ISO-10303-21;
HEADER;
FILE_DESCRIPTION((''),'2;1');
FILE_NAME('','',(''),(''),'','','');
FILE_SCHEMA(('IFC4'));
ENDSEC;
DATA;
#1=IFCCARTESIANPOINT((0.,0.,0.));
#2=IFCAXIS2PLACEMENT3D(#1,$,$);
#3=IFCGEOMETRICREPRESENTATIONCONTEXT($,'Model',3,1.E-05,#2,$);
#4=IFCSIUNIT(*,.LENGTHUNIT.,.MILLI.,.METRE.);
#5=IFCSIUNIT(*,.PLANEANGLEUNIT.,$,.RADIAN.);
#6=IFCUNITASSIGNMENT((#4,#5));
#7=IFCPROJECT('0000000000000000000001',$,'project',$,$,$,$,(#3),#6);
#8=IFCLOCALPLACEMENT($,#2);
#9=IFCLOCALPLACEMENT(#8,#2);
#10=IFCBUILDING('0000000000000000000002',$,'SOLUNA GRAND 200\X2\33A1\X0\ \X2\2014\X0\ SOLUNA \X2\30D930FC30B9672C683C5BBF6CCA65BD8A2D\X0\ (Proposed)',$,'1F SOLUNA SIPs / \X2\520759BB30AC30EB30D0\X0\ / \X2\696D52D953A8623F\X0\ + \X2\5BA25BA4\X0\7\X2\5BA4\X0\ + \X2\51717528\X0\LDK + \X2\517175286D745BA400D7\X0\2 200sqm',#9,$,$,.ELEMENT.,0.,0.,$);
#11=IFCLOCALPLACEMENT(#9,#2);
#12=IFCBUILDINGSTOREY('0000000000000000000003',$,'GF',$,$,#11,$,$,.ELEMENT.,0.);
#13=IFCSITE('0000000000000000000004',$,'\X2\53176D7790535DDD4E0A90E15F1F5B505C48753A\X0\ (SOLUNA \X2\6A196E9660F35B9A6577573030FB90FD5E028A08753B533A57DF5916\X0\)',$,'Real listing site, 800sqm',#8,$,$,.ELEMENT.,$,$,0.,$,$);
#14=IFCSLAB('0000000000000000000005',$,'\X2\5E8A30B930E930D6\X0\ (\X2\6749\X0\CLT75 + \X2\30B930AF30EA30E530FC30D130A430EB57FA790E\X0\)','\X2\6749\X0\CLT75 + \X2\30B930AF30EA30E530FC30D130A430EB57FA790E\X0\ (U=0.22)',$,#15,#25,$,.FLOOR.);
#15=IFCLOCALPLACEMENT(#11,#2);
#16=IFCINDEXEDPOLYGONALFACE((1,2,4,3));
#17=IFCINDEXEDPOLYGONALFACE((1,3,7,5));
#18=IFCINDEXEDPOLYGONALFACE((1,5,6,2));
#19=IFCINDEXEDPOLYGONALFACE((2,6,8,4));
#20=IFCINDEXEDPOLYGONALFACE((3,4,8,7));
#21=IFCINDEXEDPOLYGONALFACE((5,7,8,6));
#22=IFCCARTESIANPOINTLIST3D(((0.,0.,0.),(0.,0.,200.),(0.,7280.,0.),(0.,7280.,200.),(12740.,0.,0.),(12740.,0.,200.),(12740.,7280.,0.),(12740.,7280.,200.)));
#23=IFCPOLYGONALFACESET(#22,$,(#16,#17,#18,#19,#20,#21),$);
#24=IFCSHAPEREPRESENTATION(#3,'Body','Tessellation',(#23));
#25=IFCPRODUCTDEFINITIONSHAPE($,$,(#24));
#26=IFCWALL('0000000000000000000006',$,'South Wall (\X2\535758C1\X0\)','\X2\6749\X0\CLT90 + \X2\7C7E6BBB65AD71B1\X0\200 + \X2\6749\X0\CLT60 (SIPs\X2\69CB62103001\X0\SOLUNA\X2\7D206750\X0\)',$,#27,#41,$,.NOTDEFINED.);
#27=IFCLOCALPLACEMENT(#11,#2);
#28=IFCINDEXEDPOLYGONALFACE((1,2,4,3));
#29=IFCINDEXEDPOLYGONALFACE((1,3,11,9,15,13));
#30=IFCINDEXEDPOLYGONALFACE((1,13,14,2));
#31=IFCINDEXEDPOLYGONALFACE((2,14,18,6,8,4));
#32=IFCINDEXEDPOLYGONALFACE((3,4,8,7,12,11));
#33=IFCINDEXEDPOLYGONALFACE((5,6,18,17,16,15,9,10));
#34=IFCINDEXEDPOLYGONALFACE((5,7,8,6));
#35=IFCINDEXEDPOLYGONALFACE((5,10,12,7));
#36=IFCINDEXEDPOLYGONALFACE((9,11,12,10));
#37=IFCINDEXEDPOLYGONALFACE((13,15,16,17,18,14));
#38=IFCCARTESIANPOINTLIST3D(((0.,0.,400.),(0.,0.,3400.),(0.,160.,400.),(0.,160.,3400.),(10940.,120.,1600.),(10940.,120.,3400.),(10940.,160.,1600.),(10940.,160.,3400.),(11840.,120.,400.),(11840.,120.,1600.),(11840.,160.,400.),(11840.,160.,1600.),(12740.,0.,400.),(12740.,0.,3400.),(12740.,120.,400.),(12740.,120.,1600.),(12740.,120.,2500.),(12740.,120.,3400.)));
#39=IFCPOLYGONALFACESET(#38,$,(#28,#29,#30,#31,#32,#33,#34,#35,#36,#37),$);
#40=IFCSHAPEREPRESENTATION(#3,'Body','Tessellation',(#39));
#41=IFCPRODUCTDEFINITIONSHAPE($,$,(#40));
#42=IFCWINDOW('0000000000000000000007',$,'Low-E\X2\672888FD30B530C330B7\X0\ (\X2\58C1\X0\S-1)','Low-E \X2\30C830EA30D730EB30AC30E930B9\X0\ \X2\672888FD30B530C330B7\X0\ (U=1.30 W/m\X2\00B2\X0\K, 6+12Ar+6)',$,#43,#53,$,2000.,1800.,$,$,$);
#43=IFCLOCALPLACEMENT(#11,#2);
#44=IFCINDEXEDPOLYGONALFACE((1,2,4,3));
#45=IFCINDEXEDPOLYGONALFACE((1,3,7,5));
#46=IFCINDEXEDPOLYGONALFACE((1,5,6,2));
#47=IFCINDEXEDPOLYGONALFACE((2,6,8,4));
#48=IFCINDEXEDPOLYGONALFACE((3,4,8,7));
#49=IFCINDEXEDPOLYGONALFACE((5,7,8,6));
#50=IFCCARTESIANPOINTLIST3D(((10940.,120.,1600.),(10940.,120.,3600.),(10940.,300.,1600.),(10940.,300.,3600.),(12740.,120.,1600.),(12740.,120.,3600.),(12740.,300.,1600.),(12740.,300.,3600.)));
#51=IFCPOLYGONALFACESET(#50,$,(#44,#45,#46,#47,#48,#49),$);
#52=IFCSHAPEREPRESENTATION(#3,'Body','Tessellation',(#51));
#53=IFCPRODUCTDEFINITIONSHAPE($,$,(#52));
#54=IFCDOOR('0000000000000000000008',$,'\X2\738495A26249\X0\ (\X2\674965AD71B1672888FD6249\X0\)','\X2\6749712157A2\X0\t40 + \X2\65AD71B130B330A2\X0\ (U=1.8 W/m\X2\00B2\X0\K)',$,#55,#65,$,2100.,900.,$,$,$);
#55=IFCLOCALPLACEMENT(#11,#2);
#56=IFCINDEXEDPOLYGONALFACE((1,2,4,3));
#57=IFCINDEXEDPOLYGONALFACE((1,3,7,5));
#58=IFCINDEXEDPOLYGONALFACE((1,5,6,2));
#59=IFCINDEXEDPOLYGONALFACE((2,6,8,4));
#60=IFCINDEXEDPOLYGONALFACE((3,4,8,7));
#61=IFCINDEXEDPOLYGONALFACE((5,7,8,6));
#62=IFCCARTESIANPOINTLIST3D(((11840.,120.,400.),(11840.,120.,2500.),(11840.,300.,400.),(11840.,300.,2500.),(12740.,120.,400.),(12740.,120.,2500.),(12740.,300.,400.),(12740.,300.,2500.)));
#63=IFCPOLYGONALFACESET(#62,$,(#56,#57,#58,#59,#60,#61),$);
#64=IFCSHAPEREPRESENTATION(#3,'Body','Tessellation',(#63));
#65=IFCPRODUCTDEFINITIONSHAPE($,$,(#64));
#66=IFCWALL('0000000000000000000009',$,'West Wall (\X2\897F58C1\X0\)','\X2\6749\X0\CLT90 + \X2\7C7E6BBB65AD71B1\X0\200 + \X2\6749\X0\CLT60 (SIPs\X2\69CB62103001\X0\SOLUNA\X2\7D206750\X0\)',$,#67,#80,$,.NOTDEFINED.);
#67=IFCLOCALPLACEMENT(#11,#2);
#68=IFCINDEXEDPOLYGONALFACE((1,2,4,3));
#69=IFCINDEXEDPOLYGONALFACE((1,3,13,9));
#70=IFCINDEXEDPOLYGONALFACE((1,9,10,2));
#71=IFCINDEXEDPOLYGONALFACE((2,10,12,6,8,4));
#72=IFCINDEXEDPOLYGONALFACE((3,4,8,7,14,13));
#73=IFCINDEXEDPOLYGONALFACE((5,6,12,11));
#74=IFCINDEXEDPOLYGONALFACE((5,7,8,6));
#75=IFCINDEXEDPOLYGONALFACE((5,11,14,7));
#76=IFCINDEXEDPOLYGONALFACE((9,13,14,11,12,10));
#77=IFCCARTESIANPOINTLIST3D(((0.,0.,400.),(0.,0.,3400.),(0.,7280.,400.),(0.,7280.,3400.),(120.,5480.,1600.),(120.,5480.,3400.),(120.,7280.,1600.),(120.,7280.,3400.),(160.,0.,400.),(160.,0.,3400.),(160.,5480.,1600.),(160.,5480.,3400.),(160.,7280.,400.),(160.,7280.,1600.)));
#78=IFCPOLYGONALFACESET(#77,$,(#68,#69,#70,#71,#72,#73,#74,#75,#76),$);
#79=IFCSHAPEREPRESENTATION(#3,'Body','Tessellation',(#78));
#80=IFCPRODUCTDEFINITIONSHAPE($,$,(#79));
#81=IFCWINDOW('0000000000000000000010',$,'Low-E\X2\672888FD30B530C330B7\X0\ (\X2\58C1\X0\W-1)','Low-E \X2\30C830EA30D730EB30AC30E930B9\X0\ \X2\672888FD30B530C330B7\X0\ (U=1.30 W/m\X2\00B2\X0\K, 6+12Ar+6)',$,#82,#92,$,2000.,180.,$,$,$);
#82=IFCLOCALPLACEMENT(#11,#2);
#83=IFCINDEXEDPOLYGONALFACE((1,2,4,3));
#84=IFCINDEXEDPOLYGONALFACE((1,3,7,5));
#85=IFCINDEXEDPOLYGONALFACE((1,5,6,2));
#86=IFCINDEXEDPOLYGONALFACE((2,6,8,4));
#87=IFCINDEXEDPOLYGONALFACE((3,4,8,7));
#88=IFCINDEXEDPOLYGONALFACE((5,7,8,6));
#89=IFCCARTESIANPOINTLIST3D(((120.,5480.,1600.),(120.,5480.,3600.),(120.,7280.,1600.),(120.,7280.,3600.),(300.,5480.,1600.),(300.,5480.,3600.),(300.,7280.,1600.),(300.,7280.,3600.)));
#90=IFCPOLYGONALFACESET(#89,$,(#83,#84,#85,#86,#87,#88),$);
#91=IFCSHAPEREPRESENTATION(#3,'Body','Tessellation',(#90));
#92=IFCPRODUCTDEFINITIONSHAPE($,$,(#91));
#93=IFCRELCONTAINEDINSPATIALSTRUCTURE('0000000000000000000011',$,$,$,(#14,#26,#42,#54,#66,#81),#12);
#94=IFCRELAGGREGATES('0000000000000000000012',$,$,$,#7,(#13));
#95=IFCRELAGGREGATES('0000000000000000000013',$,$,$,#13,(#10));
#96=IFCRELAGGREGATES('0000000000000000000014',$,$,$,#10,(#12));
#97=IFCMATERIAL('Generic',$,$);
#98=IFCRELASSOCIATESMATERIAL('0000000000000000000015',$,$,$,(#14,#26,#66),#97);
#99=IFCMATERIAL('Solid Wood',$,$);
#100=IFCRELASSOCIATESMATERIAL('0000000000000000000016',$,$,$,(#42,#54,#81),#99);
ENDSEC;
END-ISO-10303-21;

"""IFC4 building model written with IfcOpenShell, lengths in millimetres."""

from ifc_helpers import new_model, si_unit, frame, frame_2d, origin, place, context, project, spatial, rectangle, extrude, material, element, fill, save


model = new_model("IFC4")

# Units and contexts
model_context = context("Model", 3, precision=1e-05, world=origin())
ifc_project = project(units=[si_unit("LENGTHUNIT", "METRE", prefix="MILLI"), si_unit("PLANEANGLEUNIT", "RADIAN")], contexts=[model_context])

# Site, building, storey
site_placement = place(None, origin())
site = spatial("IfcSite", under=ifc_project, at=site_placement, Name="北海道川上郡弟子屈町 (SOLUNA 標準想定敷地・都市計画区域外)", ObjectType="Real listing site, 800sqm", CompositionType="ELEMENT", RefElevation=0.0)
building_placement = place(site_placement, origin())
building = spatial("IfcBuilding", under=site, at=building_placement, Name="SOLUNA GRAND 200㎡ — SOLUNA ベース本格宿泊施設 (Proposed)", ObjectType="1F SOLUNA SIPs / 切妻ガルバ / 業務厨房 + 客室7室 + 共用LDK + 共用浴室×2 200sqm", CompositionType="ELEMENT", ElevationOfRefHeight=0.0, ElevationOfTerrain=0.0)
storey_placement = place(building_placement, origin())
storey = spatial("IfcBuildingStorey", under=building, at=storey_placement, Name="GF", CompositionType="ELEMENT", Elevation=0.0)

# Slab
ifc_material_1 = material(Name="Generic")
slab_placement = place(storey_placement, origin())
element("IfcSlab", 1, at=slab_placement, inside=storey, material=ifc_material_1, Name="床スラブ (杉CLT75 + スクリューパイル基礎)", Description="杉CLT75 + スクリューパイル基礎 (U=0.22)", PredefinedType="FLOOR", context=model_context, shape_type="SweptSolid", body=[
    extrude(rectangle(XDim=12740.0, YDim=7280.0, at=frame_2d((6370.0, 3640.0))), origin(), (0.0, 0.0, 1.0), 200.0),
])

# Wall, openings, window, door
wall_1_placement = place(storey_placement, frame((0.0, 0.0, 200.0)))
wall_1 = element("IfcWall", 2, at=wall_1_placement, inside=storey, material=ifc_material_1, Name="South Wall (南壁)", Description="杉CLT90 + 籾殻断熱200 + 杉CLT60 (SIPs構成、SOLUNA素材)", PredefinedType="NOTDEFINED", context=model_context, shape_type="SweptSolid", body=[
    extrude(rectangle(XDim=12740.0, YDim=160.0, at=frame_2d((6370.0, 80.0))), frame((0.0, 0.0, 200.0)), (0.0, 0.0, 1.0), 3000.0),
])
opening_1_placement = place(storey_placement, frame((5470.0, 60.0, 800.0)))
opening_1 = element("IfcOpeningElement", 3, at=opening_1_placement, cuts=wall_1, PredefinedType="NOTDEFINED", context=model_context, shape_type="SweptSolid", body=[
    extrude(rectangle(XDim=1800.0, YDim=180.0, at=frame_2d((900.0, 90.0))), frame((5470.0, 60.0, 800.0)), (0.0, 0.0, 1.0), 2000.0),
])
opening_2_placement = place(storey_placement, frame((5920.0, 60.0, 200.0)))
opening_2 = element("IfcOpeningElement", 4, at=opening_2_placement, cuts=wall_1, PredefinedType="NOTDEFINED", context=model_context, shape_type="SweptSolid", body=[
    extrude(rectangle(XDim=900.0, YDim=180.0, at=frame_2d((450.0, 90.0))), frame((5920.0, 60.0, 200.0)), (0.0, 0.0, 1.0), 2100.0),
])
ifc_material_2 = material(Name="Solid Wood")
window_1_placement = place(storey_placement, frame((5470.0, 60.0, 800.0)))
window_1 = element("IfcWindow", 5, at=window_1_placement, inside=storey, material=ifc_material_2, Name="Low-E木製サッシ (壁S-1)", Description="Low-E トリプルガラス 木製サッシ (U=1.30 W/m²K, 6+12Ar+6)", OverallHeight=2000.0, OverallWidth=1800.0, context=model_context, shape_type="SweptSolid", body=[
    extrude(rectangle(XDim=1800.0, YDim=180.0, at=frame_2d((900.0, 90.0))), frame((5470.0, 60.0, 800.0)), (0.0, 0.0, 1.0), 2000.0),
])
fill(opening_1, window_1)
door_placement = place(storey_placement, frame((5920.0, 60.0, 200.0)))
door = element("IfcDoor", 6, at=door_placement, inside=storey, material=ifc_material_2, Name="玄関扉 (杉断熱木製扉)", Description="杉無垢t40 + 断熱コア (U=1.8 W/m²K)", OverallHeight=2100.0, OverallWidth=900.0, context=model_context, shape_type="SweptSolid", body=[
    extrude(rectangle(XDim=900.0, YDim=180.0, at=frame_2d((450.0, 90.0))), frame((5920.0, 60.0, 200.0)), (0.0, 0.0, 1.0), 2100.0),
])
fill(opening_2, door)

# Wall, opening, window
wall_2_placement = place(storey_placement, frame((0.0, 0.0, 200.0)))
wall_2 = element("IfcWall", 7, at=wall_2_placement, inside=storey, material=ifc_material_1, Name="West Wall (西壁)", Description="杉CLT90 + 籾殻断熱200 + 杉CLT60 (SIPs構成、SOLUNA素材)", PredefinedType="NOTDEFINED", context=model_context, shape_type="SweptSolid", body=[
    extrude(rectangle(XDim=160.0, YDim=7280.0, at=frame_2d((80.0, 3640.0))), frame((0.0, 0.0, 200.0)), (0.0, 0.0, 1.0), 3000.0),
])
opening_3_placement = place(storey_placement, frame((60.0, 2740.0, 800.0)))
opening_3 = element("IfcOpeningElement", 8, at=opening_3_placement, cuts=wall_2, PredefinedType="NOTDEFINED", context=model_context, shape_type="SweptSolid", body=[
    extrude(rectangle(XDim=180.0, YDim=1800.0, at=frame_2d((90.0, 900.0))), frame((60.0, 2740.0, 800.0)), (0.0, 0.0, 1.0), 2000.0),
])
window_2_placement = place(storey_placement, frame((60.0, 2740.0, 800.0)))
window_2 = element("IfcWindow", 9, at=window_2_placement, inside=storey, material=ifc_material_2, Name="Low-E木製サッシ (壁W-1)", Description="Low-E トリプルガラス 木製サッシ (U=1.30 W/m²K, 6+12Ar+6)", OverallHeight=2000.0, OverallWidth=180.0, context=model_context, shape_type="SweptSolid", body=[
    extrude(rectangle(XDim=180.0, YDim=1800.0, at=frame_2d((90.0, 900.0))), frame((60.0, 2740.0, 800.0)), (0.0, 0.0, 1.0), 2000.0),
])
fill(opening_3, window_2)

save(model, "model.ifc")
